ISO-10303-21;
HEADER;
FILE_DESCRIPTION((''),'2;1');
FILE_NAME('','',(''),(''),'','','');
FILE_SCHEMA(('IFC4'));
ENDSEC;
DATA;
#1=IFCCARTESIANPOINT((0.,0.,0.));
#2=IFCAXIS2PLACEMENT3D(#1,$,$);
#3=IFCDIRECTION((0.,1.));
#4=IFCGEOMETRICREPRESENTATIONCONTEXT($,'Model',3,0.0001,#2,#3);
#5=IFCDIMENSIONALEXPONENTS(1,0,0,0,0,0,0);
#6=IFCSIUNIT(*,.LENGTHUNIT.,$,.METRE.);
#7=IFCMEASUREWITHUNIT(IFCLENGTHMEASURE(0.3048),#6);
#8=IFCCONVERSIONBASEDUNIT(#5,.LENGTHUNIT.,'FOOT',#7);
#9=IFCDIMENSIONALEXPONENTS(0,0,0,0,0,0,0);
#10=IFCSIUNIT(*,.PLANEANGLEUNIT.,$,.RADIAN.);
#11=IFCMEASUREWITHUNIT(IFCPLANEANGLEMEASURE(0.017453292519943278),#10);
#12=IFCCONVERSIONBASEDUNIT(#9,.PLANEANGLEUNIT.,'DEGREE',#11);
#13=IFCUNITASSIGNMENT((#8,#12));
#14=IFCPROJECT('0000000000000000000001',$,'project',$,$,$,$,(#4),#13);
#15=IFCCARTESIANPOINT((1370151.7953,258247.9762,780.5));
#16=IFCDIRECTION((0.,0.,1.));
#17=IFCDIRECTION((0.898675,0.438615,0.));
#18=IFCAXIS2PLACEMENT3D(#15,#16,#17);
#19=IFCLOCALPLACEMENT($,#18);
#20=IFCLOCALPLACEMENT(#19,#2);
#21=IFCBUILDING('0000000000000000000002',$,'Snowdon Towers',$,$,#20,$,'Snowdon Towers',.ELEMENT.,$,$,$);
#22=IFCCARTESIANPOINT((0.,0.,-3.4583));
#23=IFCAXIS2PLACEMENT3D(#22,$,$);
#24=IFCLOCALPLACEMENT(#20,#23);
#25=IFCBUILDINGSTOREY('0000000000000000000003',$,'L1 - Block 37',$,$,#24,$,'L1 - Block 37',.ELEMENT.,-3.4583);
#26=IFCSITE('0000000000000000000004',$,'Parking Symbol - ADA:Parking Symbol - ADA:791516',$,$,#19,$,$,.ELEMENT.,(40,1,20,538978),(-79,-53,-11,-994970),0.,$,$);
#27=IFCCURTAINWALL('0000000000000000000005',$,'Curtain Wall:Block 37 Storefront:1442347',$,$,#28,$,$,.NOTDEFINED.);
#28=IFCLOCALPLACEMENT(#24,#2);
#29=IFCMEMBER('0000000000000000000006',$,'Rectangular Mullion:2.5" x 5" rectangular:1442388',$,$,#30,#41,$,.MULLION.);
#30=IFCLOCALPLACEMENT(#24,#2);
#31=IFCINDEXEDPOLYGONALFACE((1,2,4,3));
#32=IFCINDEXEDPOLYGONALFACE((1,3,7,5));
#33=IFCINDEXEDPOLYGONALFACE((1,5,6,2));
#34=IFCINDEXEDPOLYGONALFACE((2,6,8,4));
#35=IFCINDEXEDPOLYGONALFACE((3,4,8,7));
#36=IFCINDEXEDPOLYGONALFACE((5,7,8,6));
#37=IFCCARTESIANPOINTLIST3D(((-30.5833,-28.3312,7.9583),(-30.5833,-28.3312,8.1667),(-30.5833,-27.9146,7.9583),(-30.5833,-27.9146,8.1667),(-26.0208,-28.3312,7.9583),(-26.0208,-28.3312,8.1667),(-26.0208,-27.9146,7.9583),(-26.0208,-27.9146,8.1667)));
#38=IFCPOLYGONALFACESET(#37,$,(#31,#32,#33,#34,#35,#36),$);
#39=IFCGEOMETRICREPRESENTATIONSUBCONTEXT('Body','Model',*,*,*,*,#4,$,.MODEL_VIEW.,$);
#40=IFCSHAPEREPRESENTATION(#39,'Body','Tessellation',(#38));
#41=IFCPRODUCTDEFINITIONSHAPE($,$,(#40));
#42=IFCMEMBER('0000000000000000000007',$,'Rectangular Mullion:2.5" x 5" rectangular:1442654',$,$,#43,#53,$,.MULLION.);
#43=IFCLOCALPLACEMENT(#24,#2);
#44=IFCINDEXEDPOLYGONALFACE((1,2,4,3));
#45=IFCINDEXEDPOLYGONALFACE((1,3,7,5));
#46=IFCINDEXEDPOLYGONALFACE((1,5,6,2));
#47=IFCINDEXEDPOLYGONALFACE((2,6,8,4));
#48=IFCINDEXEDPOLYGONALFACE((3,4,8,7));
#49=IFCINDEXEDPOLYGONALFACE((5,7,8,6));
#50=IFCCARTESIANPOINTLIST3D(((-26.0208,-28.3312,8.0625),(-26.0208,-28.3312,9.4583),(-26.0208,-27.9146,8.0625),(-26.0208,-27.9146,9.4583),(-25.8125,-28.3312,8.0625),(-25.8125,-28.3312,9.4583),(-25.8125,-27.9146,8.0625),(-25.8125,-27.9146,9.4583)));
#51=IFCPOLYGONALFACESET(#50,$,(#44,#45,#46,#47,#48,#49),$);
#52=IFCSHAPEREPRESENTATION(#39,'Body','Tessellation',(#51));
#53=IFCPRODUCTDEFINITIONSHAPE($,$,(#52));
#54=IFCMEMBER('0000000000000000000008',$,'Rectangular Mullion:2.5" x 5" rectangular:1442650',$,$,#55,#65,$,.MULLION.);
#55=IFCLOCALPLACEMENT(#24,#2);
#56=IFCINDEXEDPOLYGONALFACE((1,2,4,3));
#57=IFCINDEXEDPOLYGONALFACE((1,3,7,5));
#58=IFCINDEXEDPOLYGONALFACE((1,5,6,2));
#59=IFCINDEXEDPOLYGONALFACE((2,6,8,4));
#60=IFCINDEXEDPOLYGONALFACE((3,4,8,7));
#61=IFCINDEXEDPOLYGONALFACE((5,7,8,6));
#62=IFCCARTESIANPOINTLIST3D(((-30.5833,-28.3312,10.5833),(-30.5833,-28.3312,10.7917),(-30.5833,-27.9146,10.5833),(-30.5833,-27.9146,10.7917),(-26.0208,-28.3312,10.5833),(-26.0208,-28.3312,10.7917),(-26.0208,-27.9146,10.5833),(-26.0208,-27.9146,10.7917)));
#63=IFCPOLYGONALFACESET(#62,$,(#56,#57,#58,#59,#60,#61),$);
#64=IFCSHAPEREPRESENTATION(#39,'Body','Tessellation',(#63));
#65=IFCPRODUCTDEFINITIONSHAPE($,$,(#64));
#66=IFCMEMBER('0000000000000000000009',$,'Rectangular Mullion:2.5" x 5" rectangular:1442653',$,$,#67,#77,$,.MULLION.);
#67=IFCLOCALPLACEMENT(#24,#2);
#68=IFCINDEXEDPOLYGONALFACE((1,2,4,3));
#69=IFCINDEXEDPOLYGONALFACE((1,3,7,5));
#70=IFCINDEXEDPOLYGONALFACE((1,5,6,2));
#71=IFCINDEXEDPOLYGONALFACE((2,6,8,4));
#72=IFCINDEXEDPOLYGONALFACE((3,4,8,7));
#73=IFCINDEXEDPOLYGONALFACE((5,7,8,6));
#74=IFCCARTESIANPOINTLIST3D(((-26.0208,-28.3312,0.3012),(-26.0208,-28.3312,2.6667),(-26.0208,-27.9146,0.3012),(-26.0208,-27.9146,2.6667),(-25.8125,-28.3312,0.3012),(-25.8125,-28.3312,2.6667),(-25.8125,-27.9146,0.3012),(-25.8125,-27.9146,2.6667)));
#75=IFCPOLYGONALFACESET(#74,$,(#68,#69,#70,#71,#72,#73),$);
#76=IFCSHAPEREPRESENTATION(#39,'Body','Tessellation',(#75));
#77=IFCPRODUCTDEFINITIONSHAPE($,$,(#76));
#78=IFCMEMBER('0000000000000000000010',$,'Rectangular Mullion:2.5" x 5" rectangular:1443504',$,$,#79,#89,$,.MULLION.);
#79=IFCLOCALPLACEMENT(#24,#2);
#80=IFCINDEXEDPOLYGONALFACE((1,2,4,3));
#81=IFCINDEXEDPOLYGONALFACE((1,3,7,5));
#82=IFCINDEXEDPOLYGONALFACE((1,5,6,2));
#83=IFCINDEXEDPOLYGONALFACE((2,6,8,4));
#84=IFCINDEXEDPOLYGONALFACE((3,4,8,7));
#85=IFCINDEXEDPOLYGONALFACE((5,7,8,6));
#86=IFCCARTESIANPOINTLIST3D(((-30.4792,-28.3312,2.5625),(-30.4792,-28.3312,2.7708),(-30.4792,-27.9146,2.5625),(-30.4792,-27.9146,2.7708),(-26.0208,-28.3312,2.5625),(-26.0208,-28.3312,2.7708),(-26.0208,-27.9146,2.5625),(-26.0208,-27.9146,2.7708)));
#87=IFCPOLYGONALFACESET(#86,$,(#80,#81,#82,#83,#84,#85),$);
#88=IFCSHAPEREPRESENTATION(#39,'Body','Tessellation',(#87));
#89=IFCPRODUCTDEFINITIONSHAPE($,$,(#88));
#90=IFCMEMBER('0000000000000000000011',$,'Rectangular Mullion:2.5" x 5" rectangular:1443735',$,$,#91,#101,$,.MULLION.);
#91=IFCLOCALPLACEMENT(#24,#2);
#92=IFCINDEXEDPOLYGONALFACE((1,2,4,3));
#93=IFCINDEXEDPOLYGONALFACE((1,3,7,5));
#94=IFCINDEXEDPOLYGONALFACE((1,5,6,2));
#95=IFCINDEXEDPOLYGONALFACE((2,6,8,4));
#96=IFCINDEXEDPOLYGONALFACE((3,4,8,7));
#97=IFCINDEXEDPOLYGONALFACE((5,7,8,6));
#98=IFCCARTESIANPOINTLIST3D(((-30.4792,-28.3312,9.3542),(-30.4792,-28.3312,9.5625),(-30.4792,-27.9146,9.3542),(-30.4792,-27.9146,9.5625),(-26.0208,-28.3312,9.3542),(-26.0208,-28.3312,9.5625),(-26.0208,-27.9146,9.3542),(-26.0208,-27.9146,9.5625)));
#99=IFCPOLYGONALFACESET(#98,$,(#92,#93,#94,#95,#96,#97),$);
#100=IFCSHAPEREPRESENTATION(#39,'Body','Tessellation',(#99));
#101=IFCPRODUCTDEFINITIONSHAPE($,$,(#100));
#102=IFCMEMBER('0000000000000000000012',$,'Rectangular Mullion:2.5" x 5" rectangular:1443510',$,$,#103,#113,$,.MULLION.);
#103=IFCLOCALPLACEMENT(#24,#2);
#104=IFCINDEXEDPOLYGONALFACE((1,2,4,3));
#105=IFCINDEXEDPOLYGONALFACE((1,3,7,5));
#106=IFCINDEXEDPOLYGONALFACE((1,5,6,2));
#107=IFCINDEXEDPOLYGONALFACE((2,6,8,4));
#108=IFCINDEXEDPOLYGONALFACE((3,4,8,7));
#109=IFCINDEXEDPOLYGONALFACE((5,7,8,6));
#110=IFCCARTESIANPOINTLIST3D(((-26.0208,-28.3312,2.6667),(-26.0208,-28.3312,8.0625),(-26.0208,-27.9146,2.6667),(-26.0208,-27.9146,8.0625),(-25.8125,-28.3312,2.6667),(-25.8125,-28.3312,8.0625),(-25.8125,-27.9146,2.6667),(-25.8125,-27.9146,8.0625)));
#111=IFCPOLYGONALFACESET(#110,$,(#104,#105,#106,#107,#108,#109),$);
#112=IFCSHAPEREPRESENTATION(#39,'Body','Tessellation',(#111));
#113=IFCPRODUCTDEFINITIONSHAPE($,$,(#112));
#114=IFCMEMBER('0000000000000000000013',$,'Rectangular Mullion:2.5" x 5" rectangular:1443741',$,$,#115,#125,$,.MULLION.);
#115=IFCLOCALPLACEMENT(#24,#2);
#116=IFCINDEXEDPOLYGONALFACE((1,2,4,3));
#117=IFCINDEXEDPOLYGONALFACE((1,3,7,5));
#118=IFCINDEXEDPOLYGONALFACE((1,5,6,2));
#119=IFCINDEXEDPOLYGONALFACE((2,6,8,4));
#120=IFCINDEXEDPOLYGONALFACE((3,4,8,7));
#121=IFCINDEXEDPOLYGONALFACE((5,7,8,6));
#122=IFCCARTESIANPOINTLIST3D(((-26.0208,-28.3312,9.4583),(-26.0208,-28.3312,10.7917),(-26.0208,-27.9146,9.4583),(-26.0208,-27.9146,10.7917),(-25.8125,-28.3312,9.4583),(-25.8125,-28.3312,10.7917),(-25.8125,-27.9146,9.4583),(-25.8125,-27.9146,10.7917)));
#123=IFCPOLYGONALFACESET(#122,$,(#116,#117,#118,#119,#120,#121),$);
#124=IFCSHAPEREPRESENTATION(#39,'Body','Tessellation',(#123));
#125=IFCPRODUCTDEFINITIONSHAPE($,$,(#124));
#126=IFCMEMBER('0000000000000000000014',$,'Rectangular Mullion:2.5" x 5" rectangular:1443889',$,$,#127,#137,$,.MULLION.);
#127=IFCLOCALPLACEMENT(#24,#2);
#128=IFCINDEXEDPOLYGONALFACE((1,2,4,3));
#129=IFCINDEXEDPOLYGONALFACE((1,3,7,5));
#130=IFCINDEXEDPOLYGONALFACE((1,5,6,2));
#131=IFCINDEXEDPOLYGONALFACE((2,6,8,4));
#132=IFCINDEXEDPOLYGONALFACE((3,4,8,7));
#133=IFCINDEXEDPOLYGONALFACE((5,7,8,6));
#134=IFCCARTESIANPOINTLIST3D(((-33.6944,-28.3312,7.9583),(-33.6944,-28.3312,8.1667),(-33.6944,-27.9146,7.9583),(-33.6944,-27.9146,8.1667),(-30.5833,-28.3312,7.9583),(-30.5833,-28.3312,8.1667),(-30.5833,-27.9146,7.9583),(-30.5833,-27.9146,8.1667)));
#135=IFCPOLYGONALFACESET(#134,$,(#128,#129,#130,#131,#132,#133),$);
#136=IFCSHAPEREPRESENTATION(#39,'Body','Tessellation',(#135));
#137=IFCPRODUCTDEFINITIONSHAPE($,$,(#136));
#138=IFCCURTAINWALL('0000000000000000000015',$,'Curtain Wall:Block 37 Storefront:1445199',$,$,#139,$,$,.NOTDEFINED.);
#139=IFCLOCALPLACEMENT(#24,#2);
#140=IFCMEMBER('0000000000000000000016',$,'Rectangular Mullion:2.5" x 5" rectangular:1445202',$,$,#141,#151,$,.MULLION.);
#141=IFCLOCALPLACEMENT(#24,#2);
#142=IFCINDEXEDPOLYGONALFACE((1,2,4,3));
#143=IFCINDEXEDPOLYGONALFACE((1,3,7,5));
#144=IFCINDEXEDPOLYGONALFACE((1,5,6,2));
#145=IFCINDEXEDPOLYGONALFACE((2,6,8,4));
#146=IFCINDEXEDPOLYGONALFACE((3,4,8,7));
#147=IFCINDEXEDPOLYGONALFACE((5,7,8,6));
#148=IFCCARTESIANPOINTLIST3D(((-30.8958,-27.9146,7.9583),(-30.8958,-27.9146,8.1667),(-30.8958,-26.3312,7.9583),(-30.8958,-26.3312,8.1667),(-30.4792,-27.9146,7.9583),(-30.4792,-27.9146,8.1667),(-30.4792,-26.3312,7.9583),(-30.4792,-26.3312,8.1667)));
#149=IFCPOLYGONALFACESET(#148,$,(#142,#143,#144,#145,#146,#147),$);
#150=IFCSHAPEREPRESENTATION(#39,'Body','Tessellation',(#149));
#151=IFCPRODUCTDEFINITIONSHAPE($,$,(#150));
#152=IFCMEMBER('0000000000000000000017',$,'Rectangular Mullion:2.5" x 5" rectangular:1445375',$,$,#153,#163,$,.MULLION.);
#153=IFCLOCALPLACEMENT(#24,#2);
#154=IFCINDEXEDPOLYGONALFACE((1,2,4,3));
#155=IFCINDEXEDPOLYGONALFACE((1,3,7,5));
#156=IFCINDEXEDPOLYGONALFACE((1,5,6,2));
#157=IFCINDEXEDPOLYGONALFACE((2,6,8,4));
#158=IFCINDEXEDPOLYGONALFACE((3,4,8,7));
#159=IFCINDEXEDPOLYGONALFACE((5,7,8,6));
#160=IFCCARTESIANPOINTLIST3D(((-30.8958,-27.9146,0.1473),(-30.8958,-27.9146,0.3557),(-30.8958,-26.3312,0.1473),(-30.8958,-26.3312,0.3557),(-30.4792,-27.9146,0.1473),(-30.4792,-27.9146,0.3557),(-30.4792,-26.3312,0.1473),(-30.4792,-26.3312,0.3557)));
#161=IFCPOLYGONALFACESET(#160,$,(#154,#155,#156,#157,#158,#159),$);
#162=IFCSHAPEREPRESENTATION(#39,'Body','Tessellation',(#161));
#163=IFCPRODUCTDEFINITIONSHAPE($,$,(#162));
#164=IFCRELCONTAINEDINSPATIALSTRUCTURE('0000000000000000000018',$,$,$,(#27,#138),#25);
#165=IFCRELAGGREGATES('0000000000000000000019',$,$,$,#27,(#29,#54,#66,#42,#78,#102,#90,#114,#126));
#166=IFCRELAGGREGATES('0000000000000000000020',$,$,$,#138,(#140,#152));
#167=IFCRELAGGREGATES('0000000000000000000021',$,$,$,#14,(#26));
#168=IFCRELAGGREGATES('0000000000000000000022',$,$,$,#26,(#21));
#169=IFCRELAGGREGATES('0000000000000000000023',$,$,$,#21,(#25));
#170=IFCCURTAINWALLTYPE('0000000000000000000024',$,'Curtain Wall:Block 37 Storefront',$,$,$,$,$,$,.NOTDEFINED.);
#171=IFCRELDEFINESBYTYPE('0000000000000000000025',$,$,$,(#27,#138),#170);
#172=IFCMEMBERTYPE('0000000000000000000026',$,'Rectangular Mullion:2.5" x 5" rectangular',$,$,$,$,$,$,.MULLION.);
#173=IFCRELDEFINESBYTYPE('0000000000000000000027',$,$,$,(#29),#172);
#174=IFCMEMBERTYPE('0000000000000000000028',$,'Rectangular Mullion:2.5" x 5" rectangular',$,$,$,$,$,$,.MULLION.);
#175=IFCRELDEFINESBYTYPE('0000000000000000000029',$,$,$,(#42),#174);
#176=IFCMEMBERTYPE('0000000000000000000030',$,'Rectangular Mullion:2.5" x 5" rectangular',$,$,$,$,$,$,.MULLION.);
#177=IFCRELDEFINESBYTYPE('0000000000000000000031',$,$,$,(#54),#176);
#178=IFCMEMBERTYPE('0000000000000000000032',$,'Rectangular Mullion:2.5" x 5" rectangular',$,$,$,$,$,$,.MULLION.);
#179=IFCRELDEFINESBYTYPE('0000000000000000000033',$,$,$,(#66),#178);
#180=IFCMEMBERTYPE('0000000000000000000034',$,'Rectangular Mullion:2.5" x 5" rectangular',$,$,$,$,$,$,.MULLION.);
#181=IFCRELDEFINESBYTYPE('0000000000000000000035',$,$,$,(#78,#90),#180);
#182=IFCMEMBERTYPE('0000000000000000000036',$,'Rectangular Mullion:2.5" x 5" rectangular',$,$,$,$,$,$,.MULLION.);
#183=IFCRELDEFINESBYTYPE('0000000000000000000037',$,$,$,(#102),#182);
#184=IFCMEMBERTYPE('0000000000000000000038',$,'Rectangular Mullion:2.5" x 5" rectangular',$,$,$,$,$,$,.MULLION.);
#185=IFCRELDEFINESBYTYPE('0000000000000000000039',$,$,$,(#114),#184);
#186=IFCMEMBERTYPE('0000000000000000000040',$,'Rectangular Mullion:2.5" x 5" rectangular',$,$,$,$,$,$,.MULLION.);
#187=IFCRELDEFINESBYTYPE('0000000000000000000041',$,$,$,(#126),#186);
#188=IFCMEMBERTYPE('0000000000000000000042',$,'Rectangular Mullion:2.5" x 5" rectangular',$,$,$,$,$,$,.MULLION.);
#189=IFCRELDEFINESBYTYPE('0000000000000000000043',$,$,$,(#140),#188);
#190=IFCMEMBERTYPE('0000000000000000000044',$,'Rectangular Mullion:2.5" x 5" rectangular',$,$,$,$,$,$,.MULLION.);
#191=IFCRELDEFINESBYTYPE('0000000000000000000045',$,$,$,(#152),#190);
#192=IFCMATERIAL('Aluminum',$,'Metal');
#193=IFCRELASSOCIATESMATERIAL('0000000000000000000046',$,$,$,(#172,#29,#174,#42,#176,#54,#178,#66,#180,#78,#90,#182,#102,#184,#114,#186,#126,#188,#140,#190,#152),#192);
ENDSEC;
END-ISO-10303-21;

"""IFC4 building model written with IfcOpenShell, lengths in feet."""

from ifc_helpers import new_model, entity, si_unit, converted_unit, direction, frame, origin, place, context, subcontext, project, spatial, indexed_curve, outline, extrude, source, transform, mapped, material, type_object, type_shapes, element, aggregate, save


model = new_model("IFC4")

# Units and contexts
model_context = context("Model", 3, precision=0.0001, world=origin(), true_north=direction((0.0, 1.0)))
body_context = subcontext(model_context, "Body", "Model", "MODEL_VIEW")
ifc_project = project(units=[converted_unit("LENGTHUNIT", "FOOT", entity("IfcLengthMeasure", 0.3048), si_unit("LENGTHUNIT", "METRE"), dimensions=[1, 0, 0, 0, 0, 0, 0]), converted_unit("PLANEANGLEUNIT", "DEGREE", entity("IfcPlaneAngleMeasure", 0.017453292519943278), si_unit("PLANEANGLEUNIT", "RADIAN"), dimensions=[0, 0, 0, 0, 0, 0, 0])], contexts=[model_context])

# Site, building, storey
site_placement = place(None, frame((1370151.7953, 258247.9762, 780.5), z_axis=(0.0, 0.0, 1.0), x_axis=(0.898675, 0.438615, 0.0)))
site = spatial("IfcSite", under=ifc_project, at=site_placement, Name="Parking Symbol - ADA:Parking Symbol - ADA:791516", CompositionType="ELEMENT", RefLatitude=(40, 1, 20, 538978), RefLongitude=(-79, -53, -11, -994970), RefElevation=0.0)
building_placement = place(site_placement, origin())
building = spatial("IfcBuilding", under=site, at=building_placement, Name="Snowdon Towers", LongName="Snowdon Towers", CompositionType="ELEMENT")
storey_placement = place(building_placement, frame((0.0, 0.0, -3.4583)))
storey = spatial("IfcBuildingStorey", under=building, at=storey_placement, Name="L1 - Block 37", LongName="L1 - Block 37", CompositionType="ELEMENT", Elevation=-3.4583)

# Curtain walls, members
curtain_wall_type_1 = type_object("IfcCurtainWallType", Name="Curtain Wall:Block 37 Storefront", PredefinedType="NOTDEFINED")
curtain_wall_1_placement = place(storey_placement, frame((0.0, 0.0, 3.4583)))
curtain_wall_1 = element("IfcCurtainWall", 1, at=curtain_wall_1_placement, inside=storey, type_object=curtain_wall_type_1, Name="Curtain Wall:Block 37 Storefront:1442347", PredefinedType="NOTDEFINED")
ifc_material_1 = material(Name="Aluminum", Category="Metal")
member_type_1 = type_object("IfcMemberType", Name="Rectangular Mullion:2.5\" x 5\" rectangular", PredefinedType="MULLION", material=ifc_material_1)
shared_shape_1 = source(origin(), body_context, "Body", "SweptSolid", [
    extrude(outline(indexed_curve([(-0.1042, -0.2083), (0.1042, -0.2083), (0.1042, 0.2083), (-0.1042, 0.2083), (-0.1042, -0.2083)], self_intersect=False)), frame((0.0, 0.0, -4.5625), z_axis=(0.0, 0.0, 1.0), x_axis=(-1.0, 0.0, 0.0)), (0.0, 0.0, 1.0), 4.5625),
])
type_shapes(member_type_1, [shared_shape_1])
member_1_placement = place(curtain_wall_1_placement, frame((-26.0208, -28.1229, 4.6042), z_axis=(1.0, 0.0, 0.0), x_axis=(0.0, 0.0, 1.0)))
member_1 = element("IfcMember", 2, at=member_1_placement, type_object=member_type_1, material=ifc_material_1, Name="Rectangular Mullion:2.5\" x 5\" rectangular:1442388", PredefinedType="MULLION", context=body_context, shape_type="MappedRepresentation", body=[
    mapped(shared_shape_1, transform((0.0, 0.0, 0.0), scale=1.0)),
])
member_type_2 = type_object("IfcMemberType", Name="Rectangular Mullion:2.5\" x 5\" rectangular", PredefinedType="MULLION", material=ifc_material_1)
shared_shape_2 = source(origin(), body_context, "Body", "SweptSolid", [
    extrude(outline(indexed_curve([(-0.1042, -0.2083), (0.1042, -0.2083), (0.1042, 0.2083), (-0.1042, 0.2083), (-0.1042, -0.2083)], self_intersect=False)), frame((0.0, 0.0, -1.3958), z_axis=(0.0, 0.0, 1.0), x_axis=(-1.0, 0.0, 0.0)), (0.0, 0.0, 1.0), 1.3958),
])
type_shapes(member_type_2, [shared_shape_2])
member_2_placement = place(curtain_wall_1_placement, frame((-25.9167, -28.1229, 4.6042), z_axis=(0.0, 0.0, -1.0), x_axis=(1.0, 0.0, 0.0)))
member_2 = element("IfcMember", 3, at=member_2_placement, type_object=member_type_2, material=ifc_material_1, Name="Rectangular Mullion:2.5\" x 5\" rectangular:1442654", PredefinedType="MULLION", context=body_context, shape_type="MappedRepresentation", body=[
    mapped(shared_shape_2, transform((0.0, 0.0, 0.0), scale=1.0)),
])
member_type_3 = type_object("IfcMemberType", Name="Rectangular Mullion:2.5\" x 5\" rectangular", PredefinedType="MULLION", material=ifc_material_1)
shared_shape_3 = source(origin(), body_context, "Body", "SweptSolid", [
    extrude(outline(indexed_curve([(-0.1042, -0.2083), (0.1042, -0.2083), (0.1042, 0.2083), (-0.1042, 0.2083), (-0.1042, -0.2083)], self_intersect=False)), frame((-0.1042, 0.0, -4.5625), z_axis=(0.0, 0.0, 1.0), x_axis=(-1.0, 0.0, 0.0)), (0.0, 0.0, 1.0), 4.5625),
])
type_shapes(member_type_3, [shared_shape_3])
member_3_placement = place(curtain_wall_1_placement, frame((-26.0208, -28.1229, 7.3333), z_axis=(1.0, 0.0, 0.0), x_axis=(0.0, 0.0, 1.0)))
member_3 = element("IfcMember", 4, at=member_3_placement, type_object=member_type_3, material=ifc_material_1, Name="Rectangular Mullion:2.5\" x 5\" rectangular:1442650", PredefinedType="MULLION", context=body_context, shape_type="MappedRepresentation", body=[
    mapped(shared_shape_3, transform((0.0, 0.0, 0.0), scale=1.0)),
])
member_type_4 = type_object("IfcMemberType", Name="Rectangular Mullion:2.5\" x 5\" rectangular", PredefinedType="MULLION", material=ifc_material_1)
shared_shape_4 = source(origin(), body_context, "Body", "SweptSolid", [
    extrude(outline(indexed_curve([(-0.1042, -0.2083), (0.1042, -0.2083), (0.1042, 0.2083), (-0.1042, 0.2083), (-0.1042, -0.2083)], self_intersect=False)), frame((0.0, 0.0, -2.3654), z_axis=(0.0, 0.0, 1.0), x_axis=(-1.0, 0.0, 0.0)), (0.0, 0.0, 1.0), 2.3654),
])
type_shapes(member_type_4, [shared_shape_4])
member_4_placement = place(curtain_wall_1_placement, frame((-25.9167, -28.1229, -3.1571), z_axis=(0.0, 0.0, -1.0), x_axis=(1.0, 0.0, 0.0)))
member_4 = element("IfcMember", 5, at=member_4_placement, type_object=member_type_4, material=ifc_material_1, Name="Rectangular Mullion:2.5\" x 5\" rectangular:1442653", PredefinedType="MULLION", context=body_context, shape_type="MappedRepresentation", body=[
    mapped(shared_shape_4, transform((0.0, 0.0, 0.0), scale=1.0)),
])
member_type_5 = type_object("IfcMemberType", Name="Rectangular Mullion:2.5\" x 5\" rectangular", PredefinedType="MULLION", material=ifc_material_1)
shared_shape_5 = source(origin(), body_context, "Body", "SweptSolid", [
    extrude(outline(indexed_curve([(-0.1042, -0.2083), (0.1042, -0.2083), (0.1042, 0.2083), (-0.1042, 0.2083), (-0.1042, -0.2083)], self_intersect=False)), frame((0.0, 0.0, -4.4583), z_axis=(0.0, 0.0, 1.0), x_axis=(-1.0, 0.0, 0.0)), (0.0, 0.0, 1.0), 4.4583),
])
type_shapes(member_type_5, [shared_shape_5])
member_5_placement = place(curtain_wall_1_placement, frame((-26.0208, -28.1229, -0.7917), z_axis=(1.0, 0.0, 0.0), x_axis=(0.0, 0.0, 1.0)))
member_5 = element("IfcMember", 6, at=member_5_placement, type_object=member_type_5, material=ifc_material_1, Name="Rectangular Mullion:2.5\" x 5\" rectangular:1443504", PredefinedType="MULLION", context=body_context, shape_type="MappedRepresentation", body=[
    mapped(shared_shape_5, transform((0.0, 0.0, 0.0), scale=1.0)),
])
member_6_placement = place(curtain_wall_1_placement, frame((-26.0208, -28.1229, 6.0), z_axis=(1.0, 0.0, 0.0), x_axis=(0.0, 0.0, 1.0)))
member_6 = element("IfcMember", 7, at=member_6_placement, type_object=member_type_5, material=ifc_material_1, Name="Rectangular Mullion:2.5\" x 5\" rectangular:1443735", PredefinedType="MULLION", context=body_context, shape_type="MappedRepresentation", body=[
    mapped(shared_shape_5, transform((0.0, 0.0, 0.0), scale=1.0)),
])
member_type_6 = type_object("IfcMemberType", Name="Rectangular Mullion:2.5\" x 5\" rectangular", PredefinedType="MULLION", material=ifc_material_1)
shared_shape_6 = source(origin(), body_context, "Body", "SweptSolid", [
    extrude(outline(indexed_curve([(-0.1042, -0.2083), (0.1042, -0.2083), (0.1042, 0.2083), (-0.1042, 0.2083), (-0.1042, -0.2083)], self_intersect=False)), frame((0.0, 0.0, -5.3958), z_axis=(0.0, 0.0, 1.0), x_axis=(-1.0, 0.0, 0.0)), (0.0, 0.0, 1.0), 5.3958),
])
type_shapes(member_type_6, [shared_shape_6])
member_7_placement = place(curtain_wall_1_placement, frame((-25.9167, -28.1229, -0.7917), z_axis=(0.0, 0.0, -1.0), x_axis=(1.0, 0.0, 0.0)))
member_7 = element("IfcMember", 8, at=member_7_placement, type_object=member_type_6, material=ifc_material_1, Name="Rectangular Mullion:2.5\" x 5\" rectangular:1443510", PredefinedType="MULLION", context=body_context, shape_type="MappedRepresentation", body=[
    mapped(shared_shape_6, transform((0.0, 0.0, 0.0), scale=1.0)),
])
member_type_7 = type_object("IfcMemberType", Name="Rectangular Mullion:2.5\" x 5\" rectangular", PredefinedType="MULLION", material=ifc_material_1)
shared_shape_7 = source(origin(), body_context, "Body", "SweptSolid", [
    extrude(outline(indexed_curve([(-0.1042, -0.2083), (0.1042, -0.2083), (0.1042, 0.2083), (-0.1042, 0.2083), (-0.1042, -0.2083)], self_intersect=False)), frame((0.0, 0.0, -1.3333), z_axis=(0.0, 0.0, 1.0), x_axis=(-1.0, 0.0, 0.0)), (0.0, 0.0, 1.0), 1.3333),
])
type_shapes(member_type_7, [shared_shape_7])
member_8_placement = place(curtain_wall_1_placement, frame((-25.9167, -28.1229, 6.0), z_axis=(0.0, 0.0, -1.0), x_axis=(1.0, 0.0, 0.0)))
member_8 = element("IfcMember", 9, at=member_8_placement, type_object=member_type_7, material=ifc_material_1, Name="Rectangular Mullion:2.5\" x 5\" rectangular:1443741", PredefinedType="MULLION", context=body_context, shape_type="MappedRepresentation", body=[
    mapped(shared_shape_7, transform((0.0, 0.0, 0.0), scale=1.0)),
])
member_type_8 = type_object("IfcMemberType", Name="Rectangular Mullion:2.5\" x 5\" rectangular", PredefinedType="MULLION", material=ifc_material_1)
shared_shape_8 = source(origin(), body_context, "Body", "SweptSolid", [
    extrude(outline(indexed_curve([(-0.1042, -0.2083), (0.1042, -0.2083), (0.1042, 0.2083), (-0.1042, 0.2083), (-0.1042, -0.2083)], self_intersect=False)), frame((0.0, 0.0, -3.1111), z_axis=(0.0, 0.0, 1.0), x_axis=(-1.0, 0.0, 0.0)), (0.0, 0.0, 1.0), 3.1111),
])
type_shapes(member_type_8, [shared_shape_8])
member_9_placement = place(curtain_wall_1_placement, frame((-30.5833, -28.1229, 4.6042), z_axis=(1.0, 0.0, 0.0), x_axis=(0.0, 0.0, 1.0)))
member_9 = element("IfcMember", 10, at=member_9_placement, type_object=member_type_8, material=ifc_material_1, Name="Rectangular Mullion:2.5\" x 5\" rectangular:1443889", PredefinedType="MULLION", context=body_context, shape_type="MappedRepresentation", body=[
    mapped(shared_shape_8, transform((0.0, 0.0, 0.0), scale=1.0)),
])
curtain_wall_2_placement = place(storey_placement, frame((0.0, 0.0, 3.4583)))
curtain_wall_2 = element("IfcCurtainWall", 11, at=curtain_wall_2_placement, inside=storey, type_object=curtain_wall_type_1, Name="Curtain Wall:Block 37 Storefront:1445199", PredefinedType="NOTDEFINED")
member_type_9 = type_object("IfcMemberType", Name="Rectangular Mullion:2.5\" x 5\" rectangular", PredefinedType="MULLION", material=ifc_material_1)
shared_shape_9 = source(origin(), body_context, "Body", "SweptSolid", [
    extrude(outline(indexed_curve([(-0.1042, -0.2083), (0.1042, -0.2083), (0.1042, 0.2083), (-0.1042, 0.2083), (-0.1042, -0.2083)], self_intersect=False)), frame((-0.1042, 0.0, -1.5833), z_axis=(0.0, 0.0, 1.0), x_axis=(-1.0, 0.0, 0.0)), (0.0, 0.0, 1.0), 1.5833),
])
type_shapes(member_type_9, [shared_shape_9])
member_10_placement = place(curtain_wall_2_placement, frame((-30.6875, -27.9146, 4.7083), z_axis=(0.0, -1.0, 0.0), x_axis=(0.0, 0.0, 1.0)))
member_10 = element("IfcMember", 12, at=member_10_placement, type_object=member_type_9, material=ifc_material_1, Name="Rectangular Mullion:2.5\" x 5\" rectangular:1445202", PredefinedType="MULLION", context=body_context, shape_type="MappedRepresentation", body=[
    mapped(shared_shape_9, transform((0.0, 0.0, 0.0), scale=1.0)),
])
member_type_10 = type_object("IfcMemberType", Name="Rectangular Mullion:2.5\" x 5\" rectangular", PredefinedType="MULLION", material=ifc_material_1)
shared_shape_10 = source(origin(), body_context, "Body", "SweptSolid", [
    extrude(outline(indexed_curve([(-0.1042, -0.2083), (0.1042, -0.2083), (0.1042, 0.2083), (-0.1042, 0.2083), (-0.1042, -0.2083)], self_intersect=False)), frame((-0.1042, 0.0, -1.5833), z_axis=(0.0, 0.0, 1.0), x_axis=(-1.0, 0.0, 0.0)), (0.0, 0.0, 1.0), 1.5833),
])
type_shapes(member_type_10, [shared_shape_10])
member_11_placement = place(curtain_wall_2_placement, frame((-30.6875, -26.3312, -3.311), z_axis=(0.0, 1.0, 0.0), x_axis=(0.0, 0.0, -1.0)))
member_11 = element("IfcMember", 13, at=member_11_placement, type_object=member_type_10, material=ifc_material_1, Name="Rectangular Mullion:2.5\" x 5\" rectangular:1445375", PredefinedType="MULLION", context=body_context, shape_type="MappedRepresentation", body=[
    mapped(shared_shape_10, transform((0.0, 0.0, 0.0), scale=1.0)),
])

aggregate(curtain_wall_1, [member_1, member_3, member_4, member_2, member_5, member_7, member_6, member_8, member_9])
aggregate(curtain_wall_2, [member_10, member_11])

save(model, "model.ifc")
